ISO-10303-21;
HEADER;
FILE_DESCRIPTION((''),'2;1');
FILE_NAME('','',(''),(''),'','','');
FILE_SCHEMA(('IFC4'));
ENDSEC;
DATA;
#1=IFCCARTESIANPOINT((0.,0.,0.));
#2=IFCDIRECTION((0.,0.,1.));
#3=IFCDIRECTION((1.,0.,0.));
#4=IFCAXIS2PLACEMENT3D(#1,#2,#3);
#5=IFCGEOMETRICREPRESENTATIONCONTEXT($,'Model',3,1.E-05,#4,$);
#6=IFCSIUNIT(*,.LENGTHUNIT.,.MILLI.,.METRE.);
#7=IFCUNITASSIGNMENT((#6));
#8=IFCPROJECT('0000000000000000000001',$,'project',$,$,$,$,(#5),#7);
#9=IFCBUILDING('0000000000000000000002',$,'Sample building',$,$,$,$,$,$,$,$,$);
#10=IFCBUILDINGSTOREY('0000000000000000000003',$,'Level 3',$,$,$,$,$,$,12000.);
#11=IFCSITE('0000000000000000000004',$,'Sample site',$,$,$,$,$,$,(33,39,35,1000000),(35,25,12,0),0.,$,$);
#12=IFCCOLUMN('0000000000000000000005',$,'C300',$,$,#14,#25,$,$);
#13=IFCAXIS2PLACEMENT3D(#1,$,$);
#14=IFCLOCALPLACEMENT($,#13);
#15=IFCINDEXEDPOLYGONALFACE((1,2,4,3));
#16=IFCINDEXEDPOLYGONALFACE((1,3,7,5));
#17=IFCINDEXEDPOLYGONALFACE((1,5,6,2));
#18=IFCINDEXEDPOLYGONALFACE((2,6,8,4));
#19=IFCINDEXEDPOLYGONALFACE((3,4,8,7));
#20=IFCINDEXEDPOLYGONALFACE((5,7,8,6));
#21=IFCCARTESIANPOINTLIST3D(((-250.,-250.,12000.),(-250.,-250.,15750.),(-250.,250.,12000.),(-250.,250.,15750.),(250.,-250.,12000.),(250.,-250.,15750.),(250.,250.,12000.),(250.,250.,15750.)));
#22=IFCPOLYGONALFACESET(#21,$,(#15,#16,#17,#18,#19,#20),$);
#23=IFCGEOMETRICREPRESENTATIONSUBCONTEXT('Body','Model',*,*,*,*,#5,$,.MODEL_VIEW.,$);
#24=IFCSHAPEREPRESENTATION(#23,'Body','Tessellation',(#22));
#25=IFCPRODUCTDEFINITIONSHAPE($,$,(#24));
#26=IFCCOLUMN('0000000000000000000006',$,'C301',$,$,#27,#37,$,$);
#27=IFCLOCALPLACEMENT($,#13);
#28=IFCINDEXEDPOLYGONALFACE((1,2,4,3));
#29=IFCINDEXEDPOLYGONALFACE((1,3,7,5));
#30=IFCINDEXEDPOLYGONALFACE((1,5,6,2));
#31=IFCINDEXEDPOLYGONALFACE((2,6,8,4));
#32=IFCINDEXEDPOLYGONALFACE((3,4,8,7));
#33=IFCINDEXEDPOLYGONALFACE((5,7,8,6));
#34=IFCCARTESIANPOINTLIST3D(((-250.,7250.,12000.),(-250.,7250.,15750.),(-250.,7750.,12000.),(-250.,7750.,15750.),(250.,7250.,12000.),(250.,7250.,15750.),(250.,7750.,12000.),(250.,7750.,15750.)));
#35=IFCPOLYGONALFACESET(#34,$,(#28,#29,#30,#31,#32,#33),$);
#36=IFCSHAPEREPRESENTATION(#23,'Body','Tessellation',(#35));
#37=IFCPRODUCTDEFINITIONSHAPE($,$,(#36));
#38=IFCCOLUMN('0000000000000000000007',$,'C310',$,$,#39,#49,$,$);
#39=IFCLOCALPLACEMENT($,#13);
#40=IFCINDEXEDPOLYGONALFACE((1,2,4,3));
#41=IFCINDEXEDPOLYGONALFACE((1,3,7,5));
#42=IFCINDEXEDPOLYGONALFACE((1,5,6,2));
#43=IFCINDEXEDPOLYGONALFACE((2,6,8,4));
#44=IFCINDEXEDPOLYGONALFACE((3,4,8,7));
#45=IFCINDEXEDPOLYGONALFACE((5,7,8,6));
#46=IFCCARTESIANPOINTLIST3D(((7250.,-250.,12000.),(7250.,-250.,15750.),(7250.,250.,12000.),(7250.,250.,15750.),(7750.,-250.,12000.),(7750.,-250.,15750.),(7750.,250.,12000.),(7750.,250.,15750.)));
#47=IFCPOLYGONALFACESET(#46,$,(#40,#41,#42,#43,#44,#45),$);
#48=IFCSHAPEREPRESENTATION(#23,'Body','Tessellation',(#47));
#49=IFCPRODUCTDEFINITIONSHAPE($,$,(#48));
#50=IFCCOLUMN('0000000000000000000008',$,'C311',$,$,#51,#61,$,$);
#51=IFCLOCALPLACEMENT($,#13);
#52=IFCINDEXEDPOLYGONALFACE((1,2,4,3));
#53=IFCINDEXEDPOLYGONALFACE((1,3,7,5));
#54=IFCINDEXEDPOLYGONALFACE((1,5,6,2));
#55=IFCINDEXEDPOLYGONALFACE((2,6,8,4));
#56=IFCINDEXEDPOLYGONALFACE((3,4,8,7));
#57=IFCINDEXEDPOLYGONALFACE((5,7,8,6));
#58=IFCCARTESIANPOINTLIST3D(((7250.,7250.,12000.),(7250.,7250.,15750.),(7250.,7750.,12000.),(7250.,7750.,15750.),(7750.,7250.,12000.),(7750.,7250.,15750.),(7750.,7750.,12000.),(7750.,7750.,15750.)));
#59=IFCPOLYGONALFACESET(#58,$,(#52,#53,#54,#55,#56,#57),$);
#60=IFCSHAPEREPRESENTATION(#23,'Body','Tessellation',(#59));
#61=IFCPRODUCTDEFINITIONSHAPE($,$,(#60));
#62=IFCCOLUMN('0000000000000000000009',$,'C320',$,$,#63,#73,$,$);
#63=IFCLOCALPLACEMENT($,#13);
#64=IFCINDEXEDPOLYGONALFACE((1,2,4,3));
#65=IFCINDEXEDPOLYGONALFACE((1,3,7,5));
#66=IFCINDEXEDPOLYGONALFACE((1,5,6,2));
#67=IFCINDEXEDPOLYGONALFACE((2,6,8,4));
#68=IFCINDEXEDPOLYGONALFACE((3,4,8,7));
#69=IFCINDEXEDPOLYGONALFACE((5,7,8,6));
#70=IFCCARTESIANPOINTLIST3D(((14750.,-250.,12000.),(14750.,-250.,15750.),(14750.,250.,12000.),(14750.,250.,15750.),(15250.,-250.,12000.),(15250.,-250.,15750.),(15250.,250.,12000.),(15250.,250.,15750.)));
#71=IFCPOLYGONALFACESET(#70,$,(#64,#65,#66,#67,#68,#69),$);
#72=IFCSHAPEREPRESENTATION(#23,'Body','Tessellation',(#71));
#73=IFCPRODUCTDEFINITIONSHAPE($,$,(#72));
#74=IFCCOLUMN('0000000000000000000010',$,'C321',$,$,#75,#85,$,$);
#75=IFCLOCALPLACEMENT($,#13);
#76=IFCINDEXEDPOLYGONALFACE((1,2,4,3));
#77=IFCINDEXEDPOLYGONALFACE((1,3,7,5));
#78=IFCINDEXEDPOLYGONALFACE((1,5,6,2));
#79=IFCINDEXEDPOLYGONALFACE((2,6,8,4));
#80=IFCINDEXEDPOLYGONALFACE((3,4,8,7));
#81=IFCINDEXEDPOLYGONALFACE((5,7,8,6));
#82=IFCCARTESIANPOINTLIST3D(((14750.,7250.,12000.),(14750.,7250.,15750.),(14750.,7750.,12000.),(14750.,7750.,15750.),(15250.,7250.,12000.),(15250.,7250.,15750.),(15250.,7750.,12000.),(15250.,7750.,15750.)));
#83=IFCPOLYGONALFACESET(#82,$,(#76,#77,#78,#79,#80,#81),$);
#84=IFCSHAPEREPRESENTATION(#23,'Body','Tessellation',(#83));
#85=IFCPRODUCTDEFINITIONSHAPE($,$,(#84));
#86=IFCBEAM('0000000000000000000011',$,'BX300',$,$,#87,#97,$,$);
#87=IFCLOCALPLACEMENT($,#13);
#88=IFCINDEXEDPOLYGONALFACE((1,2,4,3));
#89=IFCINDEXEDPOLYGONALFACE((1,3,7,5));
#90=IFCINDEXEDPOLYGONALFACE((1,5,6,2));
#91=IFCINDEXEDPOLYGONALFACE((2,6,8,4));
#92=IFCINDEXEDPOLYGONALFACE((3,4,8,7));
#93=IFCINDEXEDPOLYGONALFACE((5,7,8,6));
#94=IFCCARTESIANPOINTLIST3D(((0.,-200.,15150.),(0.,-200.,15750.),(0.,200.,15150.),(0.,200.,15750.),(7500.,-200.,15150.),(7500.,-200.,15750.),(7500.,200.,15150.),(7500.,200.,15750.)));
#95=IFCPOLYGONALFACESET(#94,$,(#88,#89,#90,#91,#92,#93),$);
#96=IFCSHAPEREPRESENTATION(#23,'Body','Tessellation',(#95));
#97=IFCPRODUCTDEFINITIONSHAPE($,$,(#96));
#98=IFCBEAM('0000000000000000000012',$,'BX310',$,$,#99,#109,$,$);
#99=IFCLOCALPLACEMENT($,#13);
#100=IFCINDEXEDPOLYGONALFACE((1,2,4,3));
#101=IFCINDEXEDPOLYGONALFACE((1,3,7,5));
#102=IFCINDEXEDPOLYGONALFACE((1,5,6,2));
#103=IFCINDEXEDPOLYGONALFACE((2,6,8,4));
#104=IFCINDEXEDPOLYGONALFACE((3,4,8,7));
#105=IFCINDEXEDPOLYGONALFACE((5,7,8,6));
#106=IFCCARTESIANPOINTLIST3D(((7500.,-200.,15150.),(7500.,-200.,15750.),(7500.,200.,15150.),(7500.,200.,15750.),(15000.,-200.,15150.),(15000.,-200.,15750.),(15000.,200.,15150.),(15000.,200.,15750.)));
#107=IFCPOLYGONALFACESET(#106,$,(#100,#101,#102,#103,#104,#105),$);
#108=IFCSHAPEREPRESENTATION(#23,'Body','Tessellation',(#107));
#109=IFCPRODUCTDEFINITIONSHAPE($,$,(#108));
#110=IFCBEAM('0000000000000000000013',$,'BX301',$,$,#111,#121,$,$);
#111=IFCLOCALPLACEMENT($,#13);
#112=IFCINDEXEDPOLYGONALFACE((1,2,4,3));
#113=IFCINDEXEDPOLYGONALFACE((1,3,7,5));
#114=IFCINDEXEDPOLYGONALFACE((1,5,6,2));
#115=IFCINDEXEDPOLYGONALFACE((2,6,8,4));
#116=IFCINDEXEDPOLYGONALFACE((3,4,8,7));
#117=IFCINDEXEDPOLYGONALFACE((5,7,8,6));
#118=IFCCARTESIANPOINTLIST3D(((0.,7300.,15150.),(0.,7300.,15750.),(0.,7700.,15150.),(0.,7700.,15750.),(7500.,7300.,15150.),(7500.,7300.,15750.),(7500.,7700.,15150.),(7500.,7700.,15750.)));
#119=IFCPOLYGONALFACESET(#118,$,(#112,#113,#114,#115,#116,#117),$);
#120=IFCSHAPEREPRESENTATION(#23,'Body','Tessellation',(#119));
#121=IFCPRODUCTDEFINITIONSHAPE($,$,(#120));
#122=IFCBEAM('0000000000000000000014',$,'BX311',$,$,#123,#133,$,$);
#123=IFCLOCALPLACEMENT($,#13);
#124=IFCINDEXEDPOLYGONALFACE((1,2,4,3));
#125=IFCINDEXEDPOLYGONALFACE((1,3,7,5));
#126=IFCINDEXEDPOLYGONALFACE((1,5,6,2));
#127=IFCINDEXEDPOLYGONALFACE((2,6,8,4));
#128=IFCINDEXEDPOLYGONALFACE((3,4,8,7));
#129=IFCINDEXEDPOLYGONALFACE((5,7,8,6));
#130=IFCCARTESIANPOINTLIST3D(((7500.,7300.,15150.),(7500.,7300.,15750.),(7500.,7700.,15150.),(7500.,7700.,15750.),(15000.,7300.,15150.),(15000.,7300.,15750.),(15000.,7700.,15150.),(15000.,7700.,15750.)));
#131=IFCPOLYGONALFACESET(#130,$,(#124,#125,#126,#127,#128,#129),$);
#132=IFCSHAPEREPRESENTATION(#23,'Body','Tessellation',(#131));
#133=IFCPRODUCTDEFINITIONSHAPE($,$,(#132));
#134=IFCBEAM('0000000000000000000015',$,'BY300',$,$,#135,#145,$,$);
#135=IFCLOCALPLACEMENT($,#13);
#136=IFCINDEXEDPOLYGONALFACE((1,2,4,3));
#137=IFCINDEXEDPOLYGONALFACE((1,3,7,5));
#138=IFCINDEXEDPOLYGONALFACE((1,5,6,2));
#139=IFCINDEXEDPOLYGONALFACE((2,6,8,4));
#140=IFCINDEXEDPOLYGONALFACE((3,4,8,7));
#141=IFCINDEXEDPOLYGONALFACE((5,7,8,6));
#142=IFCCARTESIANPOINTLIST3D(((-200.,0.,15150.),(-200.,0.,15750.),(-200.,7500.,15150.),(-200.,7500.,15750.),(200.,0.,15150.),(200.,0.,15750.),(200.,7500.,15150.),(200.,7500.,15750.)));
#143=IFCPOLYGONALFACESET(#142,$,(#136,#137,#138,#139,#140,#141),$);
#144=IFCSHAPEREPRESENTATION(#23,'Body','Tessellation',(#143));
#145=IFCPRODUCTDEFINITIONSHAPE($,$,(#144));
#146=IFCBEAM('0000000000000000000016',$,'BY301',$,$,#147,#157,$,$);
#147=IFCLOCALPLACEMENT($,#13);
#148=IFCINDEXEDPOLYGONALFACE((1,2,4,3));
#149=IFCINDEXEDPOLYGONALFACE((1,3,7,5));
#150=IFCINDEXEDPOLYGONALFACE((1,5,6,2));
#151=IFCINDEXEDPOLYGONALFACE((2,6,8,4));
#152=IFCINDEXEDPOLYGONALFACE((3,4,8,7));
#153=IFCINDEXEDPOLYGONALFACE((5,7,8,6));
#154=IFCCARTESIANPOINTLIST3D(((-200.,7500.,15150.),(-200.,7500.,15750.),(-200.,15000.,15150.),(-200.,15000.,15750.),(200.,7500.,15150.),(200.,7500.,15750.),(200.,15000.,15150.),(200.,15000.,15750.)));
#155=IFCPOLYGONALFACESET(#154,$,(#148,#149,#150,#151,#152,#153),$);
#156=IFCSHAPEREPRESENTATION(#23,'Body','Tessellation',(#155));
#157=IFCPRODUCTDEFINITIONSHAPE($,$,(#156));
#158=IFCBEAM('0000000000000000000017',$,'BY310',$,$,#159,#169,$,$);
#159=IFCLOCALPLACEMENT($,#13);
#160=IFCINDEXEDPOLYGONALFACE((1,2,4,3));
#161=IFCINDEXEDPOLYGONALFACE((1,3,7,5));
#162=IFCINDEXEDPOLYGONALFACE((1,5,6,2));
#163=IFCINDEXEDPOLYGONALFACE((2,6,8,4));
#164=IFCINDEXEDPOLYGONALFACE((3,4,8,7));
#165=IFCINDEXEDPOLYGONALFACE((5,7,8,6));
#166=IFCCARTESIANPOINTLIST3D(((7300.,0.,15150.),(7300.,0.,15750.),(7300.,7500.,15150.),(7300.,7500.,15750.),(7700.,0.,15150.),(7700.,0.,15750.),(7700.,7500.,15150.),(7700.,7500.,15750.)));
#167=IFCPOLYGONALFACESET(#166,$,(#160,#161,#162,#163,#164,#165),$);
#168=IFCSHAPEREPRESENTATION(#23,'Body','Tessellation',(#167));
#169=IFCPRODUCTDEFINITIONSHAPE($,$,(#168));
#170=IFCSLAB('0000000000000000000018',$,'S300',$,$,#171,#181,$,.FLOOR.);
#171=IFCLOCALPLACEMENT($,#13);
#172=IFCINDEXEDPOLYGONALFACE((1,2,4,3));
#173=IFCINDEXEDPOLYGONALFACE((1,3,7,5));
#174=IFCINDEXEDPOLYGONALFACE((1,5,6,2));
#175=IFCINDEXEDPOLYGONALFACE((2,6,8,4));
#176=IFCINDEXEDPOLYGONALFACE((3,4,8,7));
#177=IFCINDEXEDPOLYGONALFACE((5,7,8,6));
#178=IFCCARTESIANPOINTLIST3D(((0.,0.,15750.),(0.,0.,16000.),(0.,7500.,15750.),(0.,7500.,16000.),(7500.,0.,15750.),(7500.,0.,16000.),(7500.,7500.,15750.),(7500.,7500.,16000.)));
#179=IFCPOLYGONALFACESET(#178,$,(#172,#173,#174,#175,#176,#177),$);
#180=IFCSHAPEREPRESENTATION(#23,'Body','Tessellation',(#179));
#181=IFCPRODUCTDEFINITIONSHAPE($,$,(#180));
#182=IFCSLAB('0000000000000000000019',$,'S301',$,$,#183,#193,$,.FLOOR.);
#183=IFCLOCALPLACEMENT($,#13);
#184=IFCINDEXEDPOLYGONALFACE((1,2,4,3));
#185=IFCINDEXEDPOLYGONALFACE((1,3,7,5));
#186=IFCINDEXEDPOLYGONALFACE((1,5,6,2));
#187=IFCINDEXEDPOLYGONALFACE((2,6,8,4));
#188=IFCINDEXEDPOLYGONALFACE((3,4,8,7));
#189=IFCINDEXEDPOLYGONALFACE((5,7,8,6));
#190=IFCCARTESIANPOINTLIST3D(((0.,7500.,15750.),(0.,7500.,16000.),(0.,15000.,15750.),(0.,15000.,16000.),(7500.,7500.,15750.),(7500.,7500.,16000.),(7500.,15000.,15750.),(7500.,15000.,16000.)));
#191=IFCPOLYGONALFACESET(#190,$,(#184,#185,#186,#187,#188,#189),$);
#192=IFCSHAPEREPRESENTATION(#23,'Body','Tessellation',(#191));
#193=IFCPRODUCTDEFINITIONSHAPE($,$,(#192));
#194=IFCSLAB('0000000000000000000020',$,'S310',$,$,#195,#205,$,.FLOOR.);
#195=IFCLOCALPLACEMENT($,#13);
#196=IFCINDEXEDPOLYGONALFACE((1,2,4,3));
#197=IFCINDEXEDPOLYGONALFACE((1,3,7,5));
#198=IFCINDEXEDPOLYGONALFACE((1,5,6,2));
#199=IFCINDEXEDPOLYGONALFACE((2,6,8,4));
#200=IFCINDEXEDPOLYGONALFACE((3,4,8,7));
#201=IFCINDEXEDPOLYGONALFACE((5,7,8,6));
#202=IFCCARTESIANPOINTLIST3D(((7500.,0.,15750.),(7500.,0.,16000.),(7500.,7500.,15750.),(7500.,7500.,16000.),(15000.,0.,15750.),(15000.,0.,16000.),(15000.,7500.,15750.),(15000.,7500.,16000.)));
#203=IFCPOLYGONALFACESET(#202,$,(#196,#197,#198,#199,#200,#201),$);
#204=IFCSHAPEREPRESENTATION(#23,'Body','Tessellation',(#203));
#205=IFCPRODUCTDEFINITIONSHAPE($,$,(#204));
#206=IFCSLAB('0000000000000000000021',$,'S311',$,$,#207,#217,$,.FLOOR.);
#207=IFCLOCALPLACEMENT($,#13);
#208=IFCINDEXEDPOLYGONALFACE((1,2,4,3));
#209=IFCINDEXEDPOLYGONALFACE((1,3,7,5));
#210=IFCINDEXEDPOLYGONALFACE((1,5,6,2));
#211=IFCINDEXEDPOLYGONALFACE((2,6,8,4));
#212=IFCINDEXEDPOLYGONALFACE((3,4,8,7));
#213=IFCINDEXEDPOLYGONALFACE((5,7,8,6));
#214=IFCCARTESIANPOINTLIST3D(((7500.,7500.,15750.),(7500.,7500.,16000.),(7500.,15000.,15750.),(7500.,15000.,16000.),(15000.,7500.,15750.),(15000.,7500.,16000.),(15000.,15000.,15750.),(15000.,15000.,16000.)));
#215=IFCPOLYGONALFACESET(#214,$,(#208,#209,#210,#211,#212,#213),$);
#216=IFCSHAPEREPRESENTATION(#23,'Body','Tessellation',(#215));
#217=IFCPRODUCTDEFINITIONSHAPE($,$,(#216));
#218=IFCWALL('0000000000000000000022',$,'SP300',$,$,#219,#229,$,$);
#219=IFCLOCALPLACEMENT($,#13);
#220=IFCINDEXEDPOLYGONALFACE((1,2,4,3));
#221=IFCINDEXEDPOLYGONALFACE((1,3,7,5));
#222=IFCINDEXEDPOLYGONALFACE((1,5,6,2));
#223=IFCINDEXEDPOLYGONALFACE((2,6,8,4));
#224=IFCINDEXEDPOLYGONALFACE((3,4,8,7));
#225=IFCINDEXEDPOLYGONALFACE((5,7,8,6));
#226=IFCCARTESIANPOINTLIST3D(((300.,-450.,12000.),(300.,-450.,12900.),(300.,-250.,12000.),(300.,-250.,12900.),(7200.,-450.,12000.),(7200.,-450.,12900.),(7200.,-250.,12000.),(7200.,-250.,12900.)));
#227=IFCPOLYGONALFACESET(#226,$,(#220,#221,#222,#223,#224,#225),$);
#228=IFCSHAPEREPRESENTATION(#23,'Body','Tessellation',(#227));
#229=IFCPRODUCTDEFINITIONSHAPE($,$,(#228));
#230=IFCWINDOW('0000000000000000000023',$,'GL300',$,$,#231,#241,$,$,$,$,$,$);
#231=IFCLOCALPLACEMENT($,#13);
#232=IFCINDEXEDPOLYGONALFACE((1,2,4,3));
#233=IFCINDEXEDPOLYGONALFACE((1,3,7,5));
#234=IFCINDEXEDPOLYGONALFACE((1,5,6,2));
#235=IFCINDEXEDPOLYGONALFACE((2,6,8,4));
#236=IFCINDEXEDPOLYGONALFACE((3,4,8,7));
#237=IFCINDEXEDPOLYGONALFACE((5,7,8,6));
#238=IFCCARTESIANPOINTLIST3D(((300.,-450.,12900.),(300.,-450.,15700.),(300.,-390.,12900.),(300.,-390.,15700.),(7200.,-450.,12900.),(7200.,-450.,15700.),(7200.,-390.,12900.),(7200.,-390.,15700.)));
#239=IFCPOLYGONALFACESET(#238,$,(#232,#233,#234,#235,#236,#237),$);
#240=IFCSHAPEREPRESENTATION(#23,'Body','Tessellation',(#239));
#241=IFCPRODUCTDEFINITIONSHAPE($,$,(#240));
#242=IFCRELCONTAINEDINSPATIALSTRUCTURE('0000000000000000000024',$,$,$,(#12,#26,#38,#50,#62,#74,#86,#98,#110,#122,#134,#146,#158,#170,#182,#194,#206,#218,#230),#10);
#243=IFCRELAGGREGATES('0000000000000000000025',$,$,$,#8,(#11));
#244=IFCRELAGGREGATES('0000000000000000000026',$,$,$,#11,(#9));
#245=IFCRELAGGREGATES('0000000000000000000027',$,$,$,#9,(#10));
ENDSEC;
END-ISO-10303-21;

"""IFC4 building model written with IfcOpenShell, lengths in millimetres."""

from ifc_helpers import new_model, si_unit, frame, origin_with_axes, place, context, subcontext, project, spatial, indexed_curve, outline, extrude, element, save


model = new_model("IFC4")

# Units and contexts
model_context = context("Model", 3, precision=1e-05, world=origin_with_axes())
body_context = subcontext(model_context, "Body", "Model", "MODEL_VIEW")
ifc_project = project(units=[si_unit("LENGTHUNIT", "METRE", prefix="MILLI")], contexts=[model_context])

# Site, building, storey
site = spatial("IfcSite", under=ifc_project, Name="Sample site", RefLatitude=(33, 39, 35, 1000000), RefLongitude=(35, 25, 12, 0), RefElevation=0.0)
building = spatial("IfcBuilding", under=site, Name="Sample building")
storey = spatial("IfcBuildingStorey", under=building, Name="Level 3", Elevation=12000.0)

# Columns
for number, where, z_axis, x_axis, name in (
    (1, (-250.0, -250.0, 12000.0), (0.0, 0.0, 1.0), (1.0, 0.0, 0.0), "C300"),
    (2, (-250.0, 7250.0, 12000.0), (0.0, 0.0, 1.0), (1.0, 0.0, 0.0), "C301"),
    (3, (7250.0, -250.0, 12000.0), (0.0, 0.0, 1.0), (1.0, 0.0, 0.0), "C310"),
    (4, (7250.0, 7250.0, 12000.0), (0.0, 0.0, 1.0), (1.0, 0.0, 0.0), "C311"),
    (5, (14750.0, -250.0, 12000.0), (0.0, 0.0, 1.0), (1.0, 0.0, 0.0), "C320"),
    (6, (14750.0, 7250.0, 12000.0), (0.0, 0.0, 1.0), (1.0, 0.0, 0.0), "C321"),
):
    element("IfcColumn", number, at=place(None, frame(where, z_axis=z_axis, x_axis=x_axis)), inside=storey, Name=name, context=body_context, shape_type="SweptSolid", body=[
        extrude(outline(indexed_curve([(0.0, 0.0), (0.0, 500.0), (500.0, 500.0), (500.0, 0.0), (0.0, 0.0)], self_intersect=False)), origin_with_axes(), (0.0, 0.0, 1.0), 3750.0),
    ])

# Beams
for number, where, z_axis, x_axis, name in (
    (7, (0.0, -200.0, 15150.0), (0.0, 0.0, 1.0), (1.0, 0.0, 0.0), "BX300"),
    (8, (7500.0, -200.0, 15150.0), (0.0, 0.0, 1.0), (1.0, 0.0, 0.0), "BX310"),
    (9, (0.0, 7300.0, 15150.0), (0.0, 0.0, 1.0), (1.0, 0.0, 0.0), "BX301"),
    (10, (7500.0, 7300.0, 15150.0), (0.0, 0.0, 1.0), (1.0, 0.0, 0.0), "BX311"),
    (11, (200.0, 0.0, 15150.0), (0.0, 0.0, 1.0), (0.0, 1.0, 0.0), "BY300"),
    (12, (200.0, 7500.0, 15150.0), (0.0, 0.0, 1.0), (0.0, 1.0, 0.0), "BY301"),
    (13, (7700.0, 0.0, 15150.0), (0.0, 0.0, 1.0), (0.0, 1.0, 0.0), "BY310"),
):
    element("IfcBeam", number, at=place(None, frame(where, z_axis=z_axis, x_axis=x_axis)), inside=storey, Name=name, context=body_context, shape_type="SweptSolid", body=[
        extrude(outline(indexed_curve([(0.0, 0.0), (0.0, 400.0), (7500.0, 400.0), (7500.0, 0.0), (0.0, 0.0)], self_intersect=False)), origin_with_axes(), (0.0, 0.0, 1.0), 600.0),
    ])

# Slabs
for number, where, z_axis, x_axis, name in (
    (14, (0.0, 0.0, 15750.0), (0.0, 0.0, 1.0), (1.0, 0.0, 0.0), "S300"),
    (15, (0.0, 7500.0, 15750.0), (0.0, 0.0, 1.0), (1.0, 0.0, 0.0), "S301"),
    (16, (7500.0, 0.0, 15750.0), (0.0, 0.0, 1.0), (1.0, 0.0, 0.0), "S310"),
    (17, (7500.0, 7500.0, 15750.0), (0.0, 0.0, 1.0), (1.0, 0.0, 0.0), "S311"),
):
    element("IfcSlab", number, at=place(None, frame(where, z_axis=z_axis, x_axis=x_axis)), inside=storey, Name=name, PredefinedType="FLOOR", context=body_context, shape_type="SweptSolid", body=[
        extrude(outline(indexed_curve([(0.0, 0.0), (0.0, 7500.0), (7500.0, 7500.0), (7500.0, 0.0), (0.0, 0.0)], self_intersect=False)), origin_with_axes(), (0.0, 0.0, 1.0), 250.0),
    ])

# Wall
wall_1_placement = place(None, frame((300.0, -450.0, 12000.0), z_axis=(0.0, 0.0, 1.0), x_axis=(1.0, 0.0, 0.0)))
element("IfcWall", 18, at=wall_1_placement, inside=storey, Name="SP300", context=body_context, shape_type="SweptSolid", body=[
    extrude(outline(indexed_curve([(0.0, 0.0), (0.0, 200.0), (6900.0, 200.0), (6900.0, 0.0), (0.0, 0.0)], self_intersect=False)), origin_with_axes(), (0.0, 0.0, 1.0), 900.0),
])

# Window
window_1_placement = place(None, frame((300.0, -450.0, 12900.0), z_axis=(0.0, 0.0, 1.0), x_axis=(1.0, 0.0, 0.0)))
element("IfcWindow", 19, at=window_1_placement, inside=storey, Name="GL300", context=body_context, shape_type="SweptSolid", body=[
    extrude(outline(indexed_curve([(0.0, 0.0), (0.0, 60.0), (6900.0, 60.0), (6900.0, 0.0), (0.0, 0.0)], self_intersect=False)), origin_with_axes(), (0.0, 0.0, 1.0), 2800.0),
])

save(model, "model.ifc")
